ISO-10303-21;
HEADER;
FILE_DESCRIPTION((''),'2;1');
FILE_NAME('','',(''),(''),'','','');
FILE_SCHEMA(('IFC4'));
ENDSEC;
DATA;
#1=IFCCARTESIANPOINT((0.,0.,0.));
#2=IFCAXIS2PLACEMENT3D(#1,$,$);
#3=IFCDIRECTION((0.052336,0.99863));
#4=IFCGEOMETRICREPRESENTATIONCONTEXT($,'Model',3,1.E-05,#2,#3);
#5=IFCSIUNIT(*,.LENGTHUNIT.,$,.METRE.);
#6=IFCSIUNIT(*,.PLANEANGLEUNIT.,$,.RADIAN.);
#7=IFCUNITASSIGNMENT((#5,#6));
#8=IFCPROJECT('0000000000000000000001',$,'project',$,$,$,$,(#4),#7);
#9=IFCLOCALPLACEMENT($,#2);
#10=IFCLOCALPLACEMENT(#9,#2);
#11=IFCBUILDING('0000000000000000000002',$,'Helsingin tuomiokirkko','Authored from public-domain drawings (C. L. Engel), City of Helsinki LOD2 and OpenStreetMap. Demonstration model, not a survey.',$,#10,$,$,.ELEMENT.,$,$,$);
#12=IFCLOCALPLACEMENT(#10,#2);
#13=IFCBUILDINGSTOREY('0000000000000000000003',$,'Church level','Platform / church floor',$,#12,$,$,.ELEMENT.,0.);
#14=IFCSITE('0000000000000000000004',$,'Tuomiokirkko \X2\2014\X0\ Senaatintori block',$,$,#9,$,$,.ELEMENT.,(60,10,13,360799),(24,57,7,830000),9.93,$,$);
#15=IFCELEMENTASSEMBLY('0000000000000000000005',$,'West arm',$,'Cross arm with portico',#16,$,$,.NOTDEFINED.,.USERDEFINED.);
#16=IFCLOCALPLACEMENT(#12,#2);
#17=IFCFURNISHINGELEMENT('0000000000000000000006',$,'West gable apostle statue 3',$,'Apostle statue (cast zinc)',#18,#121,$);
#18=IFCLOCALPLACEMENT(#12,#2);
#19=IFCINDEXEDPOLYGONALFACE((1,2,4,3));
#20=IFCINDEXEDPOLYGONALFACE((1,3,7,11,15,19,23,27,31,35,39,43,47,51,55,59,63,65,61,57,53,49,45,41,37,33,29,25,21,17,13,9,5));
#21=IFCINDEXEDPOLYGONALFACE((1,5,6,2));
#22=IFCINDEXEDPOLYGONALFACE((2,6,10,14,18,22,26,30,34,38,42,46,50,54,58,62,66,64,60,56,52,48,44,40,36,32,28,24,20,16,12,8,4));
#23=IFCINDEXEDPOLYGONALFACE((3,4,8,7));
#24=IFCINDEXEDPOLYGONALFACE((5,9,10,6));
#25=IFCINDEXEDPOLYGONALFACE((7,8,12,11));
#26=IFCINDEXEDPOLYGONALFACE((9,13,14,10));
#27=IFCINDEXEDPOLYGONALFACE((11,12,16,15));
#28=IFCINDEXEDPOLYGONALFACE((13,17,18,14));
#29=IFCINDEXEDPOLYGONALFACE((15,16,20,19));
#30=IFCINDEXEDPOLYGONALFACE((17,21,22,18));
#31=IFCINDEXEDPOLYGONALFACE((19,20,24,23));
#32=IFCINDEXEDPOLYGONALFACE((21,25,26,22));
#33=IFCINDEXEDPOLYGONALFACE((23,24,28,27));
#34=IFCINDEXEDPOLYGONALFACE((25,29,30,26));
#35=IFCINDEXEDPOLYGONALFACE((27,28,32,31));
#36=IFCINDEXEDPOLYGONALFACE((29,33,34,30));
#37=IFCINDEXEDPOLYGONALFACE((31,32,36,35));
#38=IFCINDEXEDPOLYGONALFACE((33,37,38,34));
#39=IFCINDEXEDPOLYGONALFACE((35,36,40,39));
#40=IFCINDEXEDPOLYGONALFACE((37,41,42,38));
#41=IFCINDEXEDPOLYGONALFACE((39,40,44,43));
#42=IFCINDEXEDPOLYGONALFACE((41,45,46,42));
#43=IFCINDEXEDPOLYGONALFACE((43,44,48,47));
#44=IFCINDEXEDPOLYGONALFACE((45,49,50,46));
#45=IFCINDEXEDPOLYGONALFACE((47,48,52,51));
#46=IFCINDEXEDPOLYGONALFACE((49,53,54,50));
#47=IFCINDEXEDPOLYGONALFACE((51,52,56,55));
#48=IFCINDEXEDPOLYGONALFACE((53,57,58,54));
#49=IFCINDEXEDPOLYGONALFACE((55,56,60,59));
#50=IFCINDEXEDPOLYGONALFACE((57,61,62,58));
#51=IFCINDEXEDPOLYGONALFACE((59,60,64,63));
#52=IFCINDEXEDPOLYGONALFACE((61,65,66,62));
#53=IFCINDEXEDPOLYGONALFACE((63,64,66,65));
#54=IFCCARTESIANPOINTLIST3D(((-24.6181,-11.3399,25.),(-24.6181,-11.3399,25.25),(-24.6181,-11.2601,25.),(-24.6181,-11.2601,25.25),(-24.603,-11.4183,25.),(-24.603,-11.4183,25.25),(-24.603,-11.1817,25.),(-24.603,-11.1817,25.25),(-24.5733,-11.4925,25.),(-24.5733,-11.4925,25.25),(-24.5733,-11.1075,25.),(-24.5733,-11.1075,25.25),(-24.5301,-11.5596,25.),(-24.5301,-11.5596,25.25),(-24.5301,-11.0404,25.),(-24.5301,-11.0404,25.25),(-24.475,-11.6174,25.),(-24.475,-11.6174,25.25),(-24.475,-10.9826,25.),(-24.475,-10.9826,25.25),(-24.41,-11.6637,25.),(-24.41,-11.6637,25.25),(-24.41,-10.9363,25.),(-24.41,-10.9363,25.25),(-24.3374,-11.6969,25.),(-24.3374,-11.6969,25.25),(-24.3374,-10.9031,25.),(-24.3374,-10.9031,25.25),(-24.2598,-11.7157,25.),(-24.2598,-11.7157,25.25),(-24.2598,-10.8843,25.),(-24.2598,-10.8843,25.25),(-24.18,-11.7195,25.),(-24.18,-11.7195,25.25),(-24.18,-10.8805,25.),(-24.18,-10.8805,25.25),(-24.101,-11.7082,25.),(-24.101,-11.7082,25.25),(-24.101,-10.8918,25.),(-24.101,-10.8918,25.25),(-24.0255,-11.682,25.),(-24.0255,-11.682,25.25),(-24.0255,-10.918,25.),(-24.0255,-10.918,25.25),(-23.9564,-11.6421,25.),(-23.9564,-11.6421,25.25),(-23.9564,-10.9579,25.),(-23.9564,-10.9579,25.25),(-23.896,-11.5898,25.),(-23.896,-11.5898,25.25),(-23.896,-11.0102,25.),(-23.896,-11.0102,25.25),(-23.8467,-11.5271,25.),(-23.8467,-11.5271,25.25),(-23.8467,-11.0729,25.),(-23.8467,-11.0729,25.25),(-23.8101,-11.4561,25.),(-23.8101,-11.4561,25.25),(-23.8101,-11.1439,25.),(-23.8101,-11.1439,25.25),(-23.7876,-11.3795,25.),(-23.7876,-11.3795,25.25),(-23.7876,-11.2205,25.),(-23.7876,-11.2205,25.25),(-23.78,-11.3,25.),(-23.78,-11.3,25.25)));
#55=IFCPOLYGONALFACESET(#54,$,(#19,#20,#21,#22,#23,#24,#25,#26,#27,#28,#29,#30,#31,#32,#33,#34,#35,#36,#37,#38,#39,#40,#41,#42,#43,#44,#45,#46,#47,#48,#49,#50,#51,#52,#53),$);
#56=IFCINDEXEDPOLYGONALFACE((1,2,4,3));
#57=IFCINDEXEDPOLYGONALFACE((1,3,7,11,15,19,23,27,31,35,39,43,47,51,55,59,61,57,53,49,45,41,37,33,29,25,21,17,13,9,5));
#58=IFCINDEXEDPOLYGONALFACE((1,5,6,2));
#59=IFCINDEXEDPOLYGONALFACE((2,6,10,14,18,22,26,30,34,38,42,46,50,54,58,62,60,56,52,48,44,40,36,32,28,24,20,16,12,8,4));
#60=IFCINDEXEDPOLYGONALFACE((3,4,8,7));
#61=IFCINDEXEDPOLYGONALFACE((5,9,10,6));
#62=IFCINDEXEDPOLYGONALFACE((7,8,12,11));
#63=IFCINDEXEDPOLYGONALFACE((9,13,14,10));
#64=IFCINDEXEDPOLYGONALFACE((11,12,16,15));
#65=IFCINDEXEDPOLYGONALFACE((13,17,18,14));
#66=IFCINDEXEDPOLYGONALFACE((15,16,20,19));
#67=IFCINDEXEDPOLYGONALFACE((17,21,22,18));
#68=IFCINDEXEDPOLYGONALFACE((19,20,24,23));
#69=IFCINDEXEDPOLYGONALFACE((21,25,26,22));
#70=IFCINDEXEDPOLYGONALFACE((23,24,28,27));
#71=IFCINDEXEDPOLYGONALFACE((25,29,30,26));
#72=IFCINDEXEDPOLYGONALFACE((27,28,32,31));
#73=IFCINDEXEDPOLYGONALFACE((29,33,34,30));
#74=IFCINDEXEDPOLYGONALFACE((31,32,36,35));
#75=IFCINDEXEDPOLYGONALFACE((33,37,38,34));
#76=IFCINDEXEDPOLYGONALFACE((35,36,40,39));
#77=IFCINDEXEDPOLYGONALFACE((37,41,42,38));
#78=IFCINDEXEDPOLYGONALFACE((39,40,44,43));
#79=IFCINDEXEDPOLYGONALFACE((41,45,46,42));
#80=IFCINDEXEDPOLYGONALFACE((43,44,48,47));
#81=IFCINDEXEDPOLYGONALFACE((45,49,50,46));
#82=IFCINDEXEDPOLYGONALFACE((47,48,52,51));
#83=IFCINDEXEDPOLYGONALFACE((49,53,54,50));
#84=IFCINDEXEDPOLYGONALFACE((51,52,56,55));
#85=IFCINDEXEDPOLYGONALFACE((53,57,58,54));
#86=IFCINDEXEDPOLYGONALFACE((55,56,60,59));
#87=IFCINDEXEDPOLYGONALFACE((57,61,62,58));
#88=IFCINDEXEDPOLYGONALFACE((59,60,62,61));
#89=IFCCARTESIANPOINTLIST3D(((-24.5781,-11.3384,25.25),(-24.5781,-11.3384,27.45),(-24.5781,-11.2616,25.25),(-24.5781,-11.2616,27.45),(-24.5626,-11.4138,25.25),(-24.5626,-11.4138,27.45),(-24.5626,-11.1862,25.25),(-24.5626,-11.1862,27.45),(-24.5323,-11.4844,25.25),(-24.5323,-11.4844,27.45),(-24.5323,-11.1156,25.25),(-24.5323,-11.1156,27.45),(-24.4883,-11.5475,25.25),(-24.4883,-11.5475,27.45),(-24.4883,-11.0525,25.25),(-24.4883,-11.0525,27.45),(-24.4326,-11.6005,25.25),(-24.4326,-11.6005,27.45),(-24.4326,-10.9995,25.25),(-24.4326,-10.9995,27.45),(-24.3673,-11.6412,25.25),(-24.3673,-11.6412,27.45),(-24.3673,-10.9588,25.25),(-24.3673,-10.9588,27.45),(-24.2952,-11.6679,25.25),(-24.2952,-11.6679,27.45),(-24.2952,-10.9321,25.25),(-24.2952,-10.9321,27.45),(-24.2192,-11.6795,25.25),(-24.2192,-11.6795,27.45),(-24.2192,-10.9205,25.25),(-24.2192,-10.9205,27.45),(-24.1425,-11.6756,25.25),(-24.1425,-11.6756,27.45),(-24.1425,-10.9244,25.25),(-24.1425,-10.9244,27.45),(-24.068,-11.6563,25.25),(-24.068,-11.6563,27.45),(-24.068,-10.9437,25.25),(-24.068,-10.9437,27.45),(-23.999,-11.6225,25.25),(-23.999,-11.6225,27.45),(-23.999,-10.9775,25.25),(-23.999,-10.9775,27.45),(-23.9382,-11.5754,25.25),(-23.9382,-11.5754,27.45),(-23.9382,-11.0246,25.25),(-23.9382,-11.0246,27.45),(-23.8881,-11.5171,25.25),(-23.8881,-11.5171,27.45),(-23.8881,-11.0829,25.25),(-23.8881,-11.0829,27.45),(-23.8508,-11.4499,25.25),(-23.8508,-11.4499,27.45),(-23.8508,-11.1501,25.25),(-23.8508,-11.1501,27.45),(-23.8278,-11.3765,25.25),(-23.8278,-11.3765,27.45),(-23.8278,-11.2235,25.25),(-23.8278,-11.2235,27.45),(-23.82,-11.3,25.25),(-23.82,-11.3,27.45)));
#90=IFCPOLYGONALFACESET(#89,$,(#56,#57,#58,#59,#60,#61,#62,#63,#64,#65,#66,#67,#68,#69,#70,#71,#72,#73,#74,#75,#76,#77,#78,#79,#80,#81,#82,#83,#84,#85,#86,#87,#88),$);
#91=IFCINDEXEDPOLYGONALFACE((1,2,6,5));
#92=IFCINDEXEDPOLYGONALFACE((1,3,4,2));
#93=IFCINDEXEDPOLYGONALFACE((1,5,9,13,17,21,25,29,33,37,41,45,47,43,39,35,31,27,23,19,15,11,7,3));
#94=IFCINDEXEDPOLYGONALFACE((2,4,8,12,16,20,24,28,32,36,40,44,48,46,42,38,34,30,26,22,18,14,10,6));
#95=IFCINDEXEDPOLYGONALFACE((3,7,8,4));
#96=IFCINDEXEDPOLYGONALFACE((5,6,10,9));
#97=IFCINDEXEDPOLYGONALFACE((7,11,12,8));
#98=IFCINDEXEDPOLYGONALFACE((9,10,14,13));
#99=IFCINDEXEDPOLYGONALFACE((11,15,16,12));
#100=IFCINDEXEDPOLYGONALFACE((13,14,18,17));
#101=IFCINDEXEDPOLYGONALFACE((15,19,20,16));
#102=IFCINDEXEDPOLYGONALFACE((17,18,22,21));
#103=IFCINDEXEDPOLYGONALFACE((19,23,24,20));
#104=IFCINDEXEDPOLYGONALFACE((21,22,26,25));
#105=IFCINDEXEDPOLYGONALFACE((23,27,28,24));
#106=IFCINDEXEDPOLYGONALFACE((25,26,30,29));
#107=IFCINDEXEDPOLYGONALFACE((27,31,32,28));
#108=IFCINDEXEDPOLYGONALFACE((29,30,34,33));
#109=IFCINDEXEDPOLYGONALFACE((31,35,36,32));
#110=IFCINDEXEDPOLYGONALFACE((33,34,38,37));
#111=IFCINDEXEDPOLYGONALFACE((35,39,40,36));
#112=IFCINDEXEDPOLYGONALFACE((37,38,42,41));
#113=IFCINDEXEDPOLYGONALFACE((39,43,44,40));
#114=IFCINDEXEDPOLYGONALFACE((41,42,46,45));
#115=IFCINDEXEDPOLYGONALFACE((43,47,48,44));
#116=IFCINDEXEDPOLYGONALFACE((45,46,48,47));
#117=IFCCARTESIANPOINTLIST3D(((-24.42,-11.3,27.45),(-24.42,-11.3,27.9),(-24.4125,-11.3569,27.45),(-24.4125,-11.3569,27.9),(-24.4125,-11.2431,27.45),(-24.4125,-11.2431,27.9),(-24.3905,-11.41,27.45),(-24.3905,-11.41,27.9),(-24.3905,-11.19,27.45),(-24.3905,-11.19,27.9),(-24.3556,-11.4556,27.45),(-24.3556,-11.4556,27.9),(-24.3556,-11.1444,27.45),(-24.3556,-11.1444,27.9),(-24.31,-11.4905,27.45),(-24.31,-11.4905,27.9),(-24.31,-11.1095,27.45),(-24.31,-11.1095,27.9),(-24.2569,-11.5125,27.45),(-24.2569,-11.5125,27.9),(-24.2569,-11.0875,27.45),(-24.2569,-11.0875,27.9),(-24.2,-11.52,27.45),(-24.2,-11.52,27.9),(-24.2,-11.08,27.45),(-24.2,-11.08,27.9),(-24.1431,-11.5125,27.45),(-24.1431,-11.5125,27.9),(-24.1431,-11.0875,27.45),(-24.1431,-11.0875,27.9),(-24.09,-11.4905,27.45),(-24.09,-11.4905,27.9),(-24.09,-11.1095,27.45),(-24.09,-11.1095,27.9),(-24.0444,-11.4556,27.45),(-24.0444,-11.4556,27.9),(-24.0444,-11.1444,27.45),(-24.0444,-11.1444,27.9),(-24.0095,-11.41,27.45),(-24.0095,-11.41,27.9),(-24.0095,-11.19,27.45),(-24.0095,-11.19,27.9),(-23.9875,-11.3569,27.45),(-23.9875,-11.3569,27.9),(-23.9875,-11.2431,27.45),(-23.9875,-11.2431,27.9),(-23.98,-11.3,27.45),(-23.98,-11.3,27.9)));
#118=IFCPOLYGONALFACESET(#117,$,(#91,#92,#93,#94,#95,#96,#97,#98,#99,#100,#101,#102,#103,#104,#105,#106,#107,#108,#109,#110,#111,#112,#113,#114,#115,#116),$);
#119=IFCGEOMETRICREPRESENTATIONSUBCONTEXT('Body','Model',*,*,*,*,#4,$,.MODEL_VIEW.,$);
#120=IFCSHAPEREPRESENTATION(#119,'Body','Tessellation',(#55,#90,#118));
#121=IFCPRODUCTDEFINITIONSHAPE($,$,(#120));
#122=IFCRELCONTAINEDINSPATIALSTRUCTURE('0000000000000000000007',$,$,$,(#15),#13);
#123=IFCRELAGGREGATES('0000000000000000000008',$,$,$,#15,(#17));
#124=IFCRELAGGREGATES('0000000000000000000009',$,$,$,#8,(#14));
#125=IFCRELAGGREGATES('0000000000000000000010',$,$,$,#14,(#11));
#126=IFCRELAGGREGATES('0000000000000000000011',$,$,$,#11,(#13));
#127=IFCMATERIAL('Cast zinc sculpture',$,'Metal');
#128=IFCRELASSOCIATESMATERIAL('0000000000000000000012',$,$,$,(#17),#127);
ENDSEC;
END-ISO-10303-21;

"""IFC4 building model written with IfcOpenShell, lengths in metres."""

from ifc_helpers import new_model, si_unit, direction, frame, origin, origin_2d_with_axis, place, context, subcontext, project, spatial, circle, extrude, material, element, aggregate, save


model = new_model("IFC4")

# Units and contexts
model_context = context("Model", 3, precision=1e-05, world=origin(), true_north=direction((0.052336, 0.99863)))
body_context = subcontext(model_context, "Body", "Model", "MODEL_VIEW")
ifc_project = project(units=[si_unit("LENGTHUNIT", "METRE"), si_unit("PLANEANGLEUNIT", "RADIAN")], contexts=[model_context])

# Site, building, storey
site_placement = place(None, origin())
site = spatial("IfcSite", under=ifc_project, at=site_placement, Name="Tuomiokirkko — Senaatintori block", CompositionType="ELEMENT", RefLatitude=(60, 10, 13, 360799), RefLongitude=(24, 57, 7, 830000), RefElevation=9.93)
building_placement = place(site_placement, origin())
building = spatial("IfcBuilding", under=site, at=building_placement, Name="Helsingin tuomiokirkko", Description="Authored from public-domain drawings (C. L. Engel), City of Helsinki LOD2 and OpenStreetMap. Demonstration model, not a survey.", CompositionType="ELEMENT")
storey_placement = place(building_placement, origin())
storey = spatial("IfcBuildingStorey", under=building, at=storey_placement, Name="Church level", Description="Platform / church floor", CompositionType="ELEMENT", Elevation=0.0)

# Element assembly
assembly_1_placement = place(building_placement, origin())
assembly_1 = element("IfcElementAssembly", 1, at=assembly_1_placement, inside=storey, Name="West arm", ObjectType="Cross arm with portico", AssemblyPlace="NOTDEFINED", PredefinedType="USERDEFINED")

# Furnishing element
ifc_material_1 = material(Name="Cast zinc sculpture", Category="Metal")
furnishing_1_placement = place(building_placement, origin())
furnishing_1 = element("IfcFurnishingElement", 2, at=furnishing_1_placement, material=ifc_material_1, Name="West gable apostle statue 3", ObjectType="Apostle statue (cast zinc)", context=body_context, shape_type="SweptSolid", body=[
    extrude(circle(Radius=0.42, at=origin_2d_with_axis()), frame((-24.2, -11.3, 25.0)), (0.0, 0.0, 1.0), 0.25),
    extrude(circle(Radius=0.38, at=origin_2d_with_axis()), frame((-24.2, -11.3, 25.25)), (0.0, 0.0, 1.0), 2.2),
    extrude(circle(Radius=0.22, at=origin_2d_with_axis()), frame((-24.2, -11.3, 27.45)), (0.0, 0.0, 1.0), 0.45),
])
aggregate(assembly_1, [furnishing_1])

save(model, "model.ifc")
